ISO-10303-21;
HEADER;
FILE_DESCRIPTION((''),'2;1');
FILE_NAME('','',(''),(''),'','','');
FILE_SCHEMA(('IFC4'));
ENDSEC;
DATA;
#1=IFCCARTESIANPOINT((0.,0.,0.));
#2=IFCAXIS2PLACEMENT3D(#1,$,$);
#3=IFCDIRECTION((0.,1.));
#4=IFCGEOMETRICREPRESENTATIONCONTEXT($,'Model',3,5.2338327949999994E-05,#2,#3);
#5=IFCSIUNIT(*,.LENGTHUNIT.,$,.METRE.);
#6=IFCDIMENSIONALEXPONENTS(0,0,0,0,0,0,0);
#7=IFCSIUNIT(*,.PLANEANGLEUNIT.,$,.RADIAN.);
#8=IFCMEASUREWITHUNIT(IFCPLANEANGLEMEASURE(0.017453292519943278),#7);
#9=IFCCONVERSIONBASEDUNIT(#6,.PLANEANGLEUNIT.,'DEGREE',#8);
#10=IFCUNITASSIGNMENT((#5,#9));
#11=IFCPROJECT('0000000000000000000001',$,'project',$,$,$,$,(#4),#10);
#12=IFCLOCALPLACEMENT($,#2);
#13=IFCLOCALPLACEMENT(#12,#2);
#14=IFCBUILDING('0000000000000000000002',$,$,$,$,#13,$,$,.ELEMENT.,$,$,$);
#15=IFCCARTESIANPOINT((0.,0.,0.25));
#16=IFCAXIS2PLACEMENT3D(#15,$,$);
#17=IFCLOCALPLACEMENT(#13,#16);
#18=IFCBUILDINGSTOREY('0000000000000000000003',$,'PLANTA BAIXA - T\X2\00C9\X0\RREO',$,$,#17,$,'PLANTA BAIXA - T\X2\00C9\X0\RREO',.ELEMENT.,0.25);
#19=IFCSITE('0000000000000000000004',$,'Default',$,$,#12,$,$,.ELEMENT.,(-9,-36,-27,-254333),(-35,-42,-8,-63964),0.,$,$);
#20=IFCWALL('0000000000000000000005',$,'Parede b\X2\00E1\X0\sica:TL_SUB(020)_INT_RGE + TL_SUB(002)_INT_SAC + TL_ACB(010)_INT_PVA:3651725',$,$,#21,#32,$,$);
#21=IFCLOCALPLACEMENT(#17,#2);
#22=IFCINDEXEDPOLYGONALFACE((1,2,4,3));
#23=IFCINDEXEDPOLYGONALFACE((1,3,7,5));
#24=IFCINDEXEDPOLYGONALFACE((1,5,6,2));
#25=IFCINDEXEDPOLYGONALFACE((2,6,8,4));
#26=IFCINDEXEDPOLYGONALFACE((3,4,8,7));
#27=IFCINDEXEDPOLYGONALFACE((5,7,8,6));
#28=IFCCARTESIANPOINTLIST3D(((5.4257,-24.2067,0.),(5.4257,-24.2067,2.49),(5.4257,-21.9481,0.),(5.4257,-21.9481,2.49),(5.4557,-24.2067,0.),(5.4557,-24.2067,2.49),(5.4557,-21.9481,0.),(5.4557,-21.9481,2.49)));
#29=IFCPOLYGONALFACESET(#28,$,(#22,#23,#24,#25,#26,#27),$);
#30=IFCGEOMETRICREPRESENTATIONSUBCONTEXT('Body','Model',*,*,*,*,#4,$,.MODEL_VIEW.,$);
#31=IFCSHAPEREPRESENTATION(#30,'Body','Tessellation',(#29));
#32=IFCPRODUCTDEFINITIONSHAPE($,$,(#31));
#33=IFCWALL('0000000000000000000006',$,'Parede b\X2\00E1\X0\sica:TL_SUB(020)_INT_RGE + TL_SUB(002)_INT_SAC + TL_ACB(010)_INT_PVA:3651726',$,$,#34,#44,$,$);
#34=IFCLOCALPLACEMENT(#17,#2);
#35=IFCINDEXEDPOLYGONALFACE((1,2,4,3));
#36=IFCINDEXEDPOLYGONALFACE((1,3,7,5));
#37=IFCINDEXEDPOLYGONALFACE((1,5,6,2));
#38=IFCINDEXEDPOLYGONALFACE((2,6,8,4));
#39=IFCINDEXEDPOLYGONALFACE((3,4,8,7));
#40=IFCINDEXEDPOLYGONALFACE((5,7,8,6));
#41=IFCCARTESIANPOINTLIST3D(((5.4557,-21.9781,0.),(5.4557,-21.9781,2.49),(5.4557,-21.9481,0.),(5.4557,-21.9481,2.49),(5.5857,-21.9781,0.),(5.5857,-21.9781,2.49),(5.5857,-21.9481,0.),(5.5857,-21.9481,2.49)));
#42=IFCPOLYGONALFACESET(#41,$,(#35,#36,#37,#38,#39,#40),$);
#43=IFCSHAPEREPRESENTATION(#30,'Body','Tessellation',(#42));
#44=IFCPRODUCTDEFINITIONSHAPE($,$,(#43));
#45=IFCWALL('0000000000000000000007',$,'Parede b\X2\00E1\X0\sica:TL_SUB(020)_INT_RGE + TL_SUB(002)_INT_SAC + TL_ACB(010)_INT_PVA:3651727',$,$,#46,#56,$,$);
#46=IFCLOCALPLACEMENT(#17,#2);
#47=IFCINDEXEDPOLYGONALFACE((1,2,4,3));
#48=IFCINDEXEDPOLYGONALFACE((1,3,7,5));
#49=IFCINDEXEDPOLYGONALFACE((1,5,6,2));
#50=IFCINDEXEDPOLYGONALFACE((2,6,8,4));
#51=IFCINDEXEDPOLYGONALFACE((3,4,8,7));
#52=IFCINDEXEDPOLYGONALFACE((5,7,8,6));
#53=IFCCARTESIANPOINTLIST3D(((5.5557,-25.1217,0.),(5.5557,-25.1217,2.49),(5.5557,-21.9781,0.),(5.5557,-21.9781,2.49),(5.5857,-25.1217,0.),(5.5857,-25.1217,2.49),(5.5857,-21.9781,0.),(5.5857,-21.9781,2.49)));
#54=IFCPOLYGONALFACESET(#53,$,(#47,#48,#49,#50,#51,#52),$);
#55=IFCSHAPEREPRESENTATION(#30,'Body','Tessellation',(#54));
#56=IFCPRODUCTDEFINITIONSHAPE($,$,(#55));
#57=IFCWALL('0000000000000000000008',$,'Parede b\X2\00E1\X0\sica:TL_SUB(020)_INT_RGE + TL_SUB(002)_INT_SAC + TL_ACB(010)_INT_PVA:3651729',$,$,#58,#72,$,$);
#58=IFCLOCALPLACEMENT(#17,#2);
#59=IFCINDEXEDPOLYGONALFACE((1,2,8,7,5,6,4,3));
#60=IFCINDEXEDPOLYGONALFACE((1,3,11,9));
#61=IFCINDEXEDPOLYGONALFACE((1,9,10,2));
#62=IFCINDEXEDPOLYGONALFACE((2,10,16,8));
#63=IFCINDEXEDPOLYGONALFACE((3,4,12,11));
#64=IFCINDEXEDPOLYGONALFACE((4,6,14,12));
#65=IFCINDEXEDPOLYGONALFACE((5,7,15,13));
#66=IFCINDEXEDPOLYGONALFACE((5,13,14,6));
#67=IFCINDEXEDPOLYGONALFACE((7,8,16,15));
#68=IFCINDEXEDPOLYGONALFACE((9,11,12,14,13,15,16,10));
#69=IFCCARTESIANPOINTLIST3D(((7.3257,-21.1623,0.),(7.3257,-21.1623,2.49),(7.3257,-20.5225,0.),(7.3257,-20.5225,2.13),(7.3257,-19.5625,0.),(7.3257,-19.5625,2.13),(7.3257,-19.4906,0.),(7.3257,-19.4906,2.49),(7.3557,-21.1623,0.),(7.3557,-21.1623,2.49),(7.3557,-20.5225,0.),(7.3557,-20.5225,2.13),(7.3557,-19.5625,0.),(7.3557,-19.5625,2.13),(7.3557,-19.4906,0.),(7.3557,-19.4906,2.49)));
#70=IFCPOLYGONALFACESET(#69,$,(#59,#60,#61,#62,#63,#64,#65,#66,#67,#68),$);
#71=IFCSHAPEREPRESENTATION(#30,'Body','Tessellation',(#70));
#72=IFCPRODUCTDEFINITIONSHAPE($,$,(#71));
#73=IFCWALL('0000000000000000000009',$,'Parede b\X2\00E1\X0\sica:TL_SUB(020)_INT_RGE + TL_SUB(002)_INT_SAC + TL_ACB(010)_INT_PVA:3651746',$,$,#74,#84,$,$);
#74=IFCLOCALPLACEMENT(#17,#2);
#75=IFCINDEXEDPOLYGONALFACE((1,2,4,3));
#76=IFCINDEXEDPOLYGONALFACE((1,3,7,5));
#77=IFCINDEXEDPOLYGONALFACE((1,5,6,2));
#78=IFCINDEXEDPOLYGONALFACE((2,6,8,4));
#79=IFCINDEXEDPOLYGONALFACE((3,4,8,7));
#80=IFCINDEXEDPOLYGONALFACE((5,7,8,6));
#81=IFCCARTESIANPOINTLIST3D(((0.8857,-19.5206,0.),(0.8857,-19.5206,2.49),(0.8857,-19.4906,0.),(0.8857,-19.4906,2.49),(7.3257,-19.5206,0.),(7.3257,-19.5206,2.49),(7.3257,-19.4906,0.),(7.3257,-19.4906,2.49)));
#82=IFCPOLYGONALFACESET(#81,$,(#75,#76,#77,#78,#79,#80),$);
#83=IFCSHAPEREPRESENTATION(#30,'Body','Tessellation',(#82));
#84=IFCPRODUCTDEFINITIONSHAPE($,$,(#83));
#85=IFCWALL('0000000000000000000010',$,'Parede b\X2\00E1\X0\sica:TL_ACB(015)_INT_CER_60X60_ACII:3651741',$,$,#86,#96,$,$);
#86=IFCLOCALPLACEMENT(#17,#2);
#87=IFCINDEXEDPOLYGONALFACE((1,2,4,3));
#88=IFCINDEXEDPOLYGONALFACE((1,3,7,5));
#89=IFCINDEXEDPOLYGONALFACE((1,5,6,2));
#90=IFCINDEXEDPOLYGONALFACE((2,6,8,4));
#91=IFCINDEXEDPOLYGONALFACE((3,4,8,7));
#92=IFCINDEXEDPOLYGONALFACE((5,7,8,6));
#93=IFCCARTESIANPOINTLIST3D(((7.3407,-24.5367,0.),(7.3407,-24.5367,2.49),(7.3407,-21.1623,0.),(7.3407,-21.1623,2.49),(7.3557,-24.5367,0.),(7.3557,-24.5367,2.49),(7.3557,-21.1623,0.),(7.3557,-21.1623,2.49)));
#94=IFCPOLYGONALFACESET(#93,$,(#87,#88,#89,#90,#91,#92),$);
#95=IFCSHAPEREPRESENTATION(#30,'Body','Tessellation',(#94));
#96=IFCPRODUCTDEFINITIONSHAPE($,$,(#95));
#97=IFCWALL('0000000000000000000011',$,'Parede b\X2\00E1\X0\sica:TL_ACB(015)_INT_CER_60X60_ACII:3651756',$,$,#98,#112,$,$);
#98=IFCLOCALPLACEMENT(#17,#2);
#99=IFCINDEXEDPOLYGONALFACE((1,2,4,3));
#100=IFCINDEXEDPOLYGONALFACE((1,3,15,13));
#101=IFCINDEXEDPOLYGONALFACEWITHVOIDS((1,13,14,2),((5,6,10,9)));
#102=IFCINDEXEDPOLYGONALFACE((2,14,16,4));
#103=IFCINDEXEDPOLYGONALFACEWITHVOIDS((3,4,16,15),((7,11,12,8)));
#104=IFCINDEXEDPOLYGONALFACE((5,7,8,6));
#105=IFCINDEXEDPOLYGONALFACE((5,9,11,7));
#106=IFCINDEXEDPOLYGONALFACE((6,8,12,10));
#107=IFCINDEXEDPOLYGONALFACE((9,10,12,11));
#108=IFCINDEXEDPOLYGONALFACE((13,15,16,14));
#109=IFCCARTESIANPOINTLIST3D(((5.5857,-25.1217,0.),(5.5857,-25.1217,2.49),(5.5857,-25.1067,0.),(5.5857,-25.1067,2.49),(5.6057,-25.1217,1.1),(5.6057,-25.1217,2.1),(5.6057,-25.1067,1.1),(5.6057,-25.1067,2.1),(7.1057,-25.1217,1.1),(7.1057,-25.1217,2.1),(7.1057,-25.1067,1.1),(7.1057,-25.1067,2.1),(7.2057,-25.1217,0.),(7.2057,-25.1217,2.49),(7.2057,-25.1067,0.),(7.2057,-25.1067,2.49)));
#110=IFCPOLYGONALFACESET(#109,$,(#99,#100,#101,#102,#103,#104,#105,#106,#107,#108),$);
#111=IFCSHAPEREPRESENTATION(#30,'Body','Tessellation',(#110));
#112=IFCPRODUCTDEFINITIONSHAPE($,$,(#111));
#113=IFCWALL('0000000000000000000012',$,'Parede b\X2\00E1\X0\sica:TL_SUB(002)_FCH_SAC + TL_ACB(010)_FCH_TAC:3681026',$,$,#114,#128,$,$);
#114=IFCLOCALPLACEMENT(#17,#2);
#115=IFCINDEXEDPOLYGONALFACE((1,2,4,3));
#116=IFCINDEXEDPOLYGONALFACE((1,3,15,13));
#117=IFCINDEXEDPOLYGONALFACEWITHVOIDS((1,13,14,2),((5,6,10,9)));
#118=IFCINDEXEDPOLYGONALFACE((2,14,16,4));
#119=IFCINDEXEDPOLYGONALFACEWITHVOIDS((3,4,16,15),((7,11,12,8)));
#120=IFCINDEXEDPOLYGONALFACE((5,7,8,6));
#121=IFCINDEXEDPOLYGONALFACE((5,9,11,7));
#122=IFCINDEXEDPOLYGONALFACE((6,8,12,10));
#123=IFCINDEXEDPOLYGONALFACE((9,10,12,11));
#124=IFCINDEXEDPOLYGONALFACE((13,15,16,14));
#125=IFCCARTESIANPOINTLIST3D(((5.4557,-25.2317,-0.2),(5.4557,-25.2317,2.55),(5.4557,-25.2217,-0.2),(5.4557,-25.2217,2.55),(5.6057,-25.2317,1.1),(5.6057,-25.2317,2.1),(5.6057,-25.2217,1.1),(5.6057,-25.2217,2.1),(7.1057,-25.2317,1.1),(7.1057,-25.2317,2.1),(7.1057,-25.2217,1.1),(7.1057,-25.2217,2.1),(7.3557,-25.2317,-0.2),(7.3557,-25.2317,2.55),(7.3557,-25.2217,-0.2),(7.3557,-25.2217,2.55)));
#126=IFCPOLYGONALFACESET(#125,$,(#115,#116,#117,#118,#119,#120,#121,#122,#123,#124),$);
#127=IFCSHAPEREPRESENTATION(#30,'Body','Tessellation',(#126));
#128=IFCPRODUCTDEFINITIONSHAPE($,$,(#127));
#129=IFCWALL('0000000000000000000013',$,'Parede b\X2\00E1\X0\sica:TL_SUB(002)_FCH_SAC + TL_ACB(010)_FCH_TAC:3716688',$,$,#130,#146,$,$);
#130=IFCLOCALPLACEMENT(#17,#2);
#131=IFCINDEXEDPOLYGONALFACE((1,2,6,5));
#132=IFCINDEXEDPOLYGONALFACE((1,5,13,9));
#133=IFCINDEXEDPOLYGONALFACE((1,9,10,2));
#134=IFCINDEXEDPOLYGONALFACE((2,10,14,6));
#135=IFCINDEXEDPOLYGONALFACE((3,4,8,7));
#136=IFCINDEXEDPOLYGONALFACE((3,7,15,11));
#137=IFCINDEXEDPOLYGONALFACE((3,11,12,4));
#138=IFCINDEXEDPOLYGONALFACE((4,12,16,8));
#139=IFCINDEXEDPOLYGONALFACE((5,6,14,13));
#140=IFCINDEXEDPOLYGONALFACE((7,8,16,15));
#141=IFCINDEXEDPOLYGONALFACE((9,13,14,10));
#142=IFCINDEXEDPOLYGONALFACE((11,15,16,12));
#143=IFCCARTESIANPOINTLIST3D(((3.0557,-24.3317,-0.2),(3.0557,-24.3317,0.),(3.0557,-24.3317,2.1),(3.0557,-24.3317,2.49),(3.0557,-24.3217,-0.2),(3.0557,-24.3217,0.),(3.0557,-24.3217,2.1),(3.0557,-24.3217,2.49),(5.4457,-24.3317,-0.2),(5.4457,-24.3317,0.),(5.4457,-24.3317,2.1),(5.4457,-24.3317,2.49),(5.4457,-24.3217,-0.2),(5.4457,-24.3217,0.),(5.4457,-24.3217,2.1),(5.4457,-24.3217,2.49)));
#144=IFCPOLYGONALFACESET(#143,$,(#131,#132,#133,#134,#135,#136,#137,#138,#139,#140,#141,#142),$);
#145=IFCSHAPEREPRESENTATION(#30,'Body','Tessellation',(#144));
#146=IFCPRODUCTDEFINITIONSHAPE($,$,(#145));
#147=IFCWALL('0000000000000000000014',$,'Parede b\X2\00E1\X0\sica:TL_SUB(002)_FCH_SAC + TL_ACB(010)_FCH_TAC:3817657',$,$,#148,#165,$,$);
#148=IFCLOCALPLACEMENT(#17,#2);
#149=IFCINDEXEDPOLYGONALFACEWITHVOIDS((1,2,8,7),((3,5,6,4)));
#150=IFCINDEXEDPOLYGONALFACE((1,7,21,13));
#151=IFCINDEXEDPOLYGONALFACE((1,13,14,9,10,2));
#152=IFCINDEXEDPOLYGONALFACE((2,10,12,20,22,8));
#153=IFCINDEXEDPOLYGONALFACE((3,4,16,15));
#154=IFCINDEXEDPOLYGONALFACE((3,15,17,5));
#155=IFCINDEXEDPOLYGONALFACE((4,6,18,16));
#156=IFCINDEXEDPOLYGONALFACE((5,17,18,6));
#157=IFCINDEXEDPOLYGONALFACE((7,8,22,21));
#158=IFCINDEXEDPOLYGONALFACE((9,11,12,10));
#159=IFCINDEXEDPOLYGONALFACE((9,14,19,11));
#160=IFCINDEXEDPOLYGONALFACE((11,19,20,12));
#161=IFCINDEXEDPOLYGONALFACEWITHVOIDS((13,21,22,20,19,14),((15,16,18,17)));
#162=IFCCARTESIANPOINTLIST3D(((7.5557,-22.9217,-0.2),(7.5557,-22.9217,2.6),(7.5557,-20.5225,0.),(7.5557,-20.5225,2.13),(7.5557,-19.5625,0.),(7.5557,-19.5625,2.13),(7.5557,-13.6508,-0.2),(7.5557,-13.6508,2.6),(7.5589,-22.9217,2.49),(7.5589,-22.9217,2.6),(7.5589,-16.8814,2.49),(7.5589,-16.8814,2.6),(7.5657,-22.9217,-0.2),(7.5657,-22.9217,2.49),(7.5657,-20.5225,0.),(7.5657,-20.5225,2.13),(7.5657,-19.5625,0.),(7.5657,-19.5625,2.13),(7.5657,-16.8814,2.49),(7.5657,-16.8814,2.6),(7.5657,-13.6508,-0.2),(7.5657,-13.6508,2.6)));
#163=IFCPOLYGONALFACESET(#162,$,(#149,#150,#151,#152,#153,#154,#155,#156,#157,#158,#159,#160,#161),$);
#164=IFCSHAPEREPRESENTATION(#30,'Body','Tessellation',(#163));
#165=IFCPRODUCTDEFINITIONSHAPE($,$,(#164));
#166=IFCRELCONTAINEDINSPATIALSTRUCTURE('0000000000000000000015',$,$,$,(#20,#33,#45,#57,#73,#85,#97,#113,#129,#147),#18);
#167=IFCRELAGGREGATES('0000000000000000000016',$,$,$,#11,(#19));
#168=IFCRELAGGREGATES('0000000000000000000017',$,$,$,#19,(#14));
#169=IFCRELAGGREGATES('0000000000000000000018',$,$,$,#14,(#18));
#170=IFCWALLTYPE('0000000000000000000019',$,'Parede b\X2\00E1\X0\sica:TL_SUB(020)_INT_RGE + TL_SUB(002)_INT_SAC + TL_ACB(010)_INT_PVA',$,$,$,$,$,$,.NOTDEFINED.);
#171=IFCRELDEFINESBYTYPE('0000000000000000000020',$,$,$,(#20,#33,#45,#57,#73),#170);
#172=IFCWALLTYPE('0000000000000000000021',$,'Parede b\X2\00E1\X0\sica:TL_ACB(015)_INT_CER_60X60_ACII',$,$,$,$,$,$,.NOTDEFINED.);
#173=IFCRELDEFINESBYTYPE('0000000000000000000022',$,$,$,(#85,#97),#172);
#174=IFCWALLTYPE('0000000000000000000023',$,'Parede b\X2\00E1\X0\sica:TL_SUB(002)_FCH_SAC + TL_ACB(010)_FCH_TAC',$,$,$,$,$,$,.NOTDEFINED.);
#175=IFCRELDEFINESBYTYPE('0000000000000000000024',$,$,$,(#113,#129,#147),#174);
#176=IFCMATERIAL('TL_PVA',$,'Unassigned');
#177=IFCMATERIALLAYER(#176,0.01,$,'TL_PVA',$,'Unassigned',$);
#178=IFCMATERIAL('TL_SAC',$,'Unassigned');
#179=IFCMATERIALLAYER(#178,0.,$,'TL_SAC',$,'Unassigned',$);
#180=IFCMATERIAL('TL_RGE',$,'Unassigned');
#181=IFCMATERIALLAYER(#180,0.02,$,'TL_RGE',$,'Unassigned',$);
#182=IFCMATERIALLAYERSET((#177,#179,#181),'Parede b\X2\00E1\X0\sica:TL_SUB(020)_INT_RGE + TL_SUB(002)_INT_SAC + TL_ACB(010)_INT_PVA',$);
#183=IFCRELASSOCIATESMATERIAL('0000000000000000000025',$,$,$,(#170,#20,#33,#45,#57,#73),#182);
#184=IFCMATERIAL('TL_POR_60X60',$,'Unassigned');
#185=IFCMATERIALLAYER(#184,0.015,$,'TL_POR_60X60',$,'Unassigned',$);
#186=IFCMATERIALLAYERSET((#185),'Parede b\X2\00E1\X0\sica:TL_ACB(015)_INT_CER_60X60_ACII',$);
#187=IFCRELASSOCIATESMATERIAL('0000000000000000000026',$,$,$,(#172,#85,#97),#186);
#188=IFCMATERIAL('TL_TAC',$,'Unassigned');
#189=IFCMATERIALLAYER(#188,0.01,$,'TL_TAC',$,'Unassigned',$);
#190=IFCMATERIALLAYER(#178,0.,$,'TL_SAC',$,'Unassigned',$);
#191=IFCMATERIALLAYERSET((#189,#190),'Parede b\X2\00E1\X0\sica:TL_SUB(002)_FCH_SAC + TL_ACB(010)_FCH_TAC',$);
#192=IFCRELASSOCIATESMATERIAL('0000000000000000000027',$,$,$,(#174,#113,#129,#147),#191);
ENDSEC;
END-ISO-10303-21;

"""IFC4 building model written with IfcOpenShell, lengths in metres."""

from ifc_helpers import new_model, entity, si_unit, converted_unit, direction, frame, frame_2d, origin, place, context, subcontext, project, spatial, polyline, rectangle, extrude, clip, bounded_halfspace, material, layer, layer_set, layer_usage, type_object, element, save


model = new_model("IFC4")

# Units and contexts
model_context = context("Model", 3, precision=5.2338327949999994e-05, world=origin(), true_north=direction((0.0, 1.0)))
body_context = subcontext(model_context, "Body", "Model", "MODEL_VIEW")
ifc_project = project(units=[si_unit("LENGTHUNIT", "METRE"), converted_unit("PLANEANGLEUNIT", "DEGREE", entity("IfcPlaneAngleMeasure", 0.017453292519943278), si_unit("PLANEANGLEUNIT", "RADIAN"), dimensions=[0, 0, 0, 0, 0, 0, 0])], contexts=[model_context])

# Site, building, storey
site_placement = place(None, frame((0.0, 0.0, 0.0)))
site = spatial("IfcSite", under=ifc_project, at=site_placement, Name="Default", CompositionType="ELEMENT", RefLatitude=(-9, -36, -27, -254333), RefLongitude=(-35, -42, -8, -63964), RefElevation=0.0)
building_placement = place(site_placement, origin())
building = spatial("IfcBuilding", under=site, at=building_placement, CompositionType="ELEMENT")
storey_placement = place(building_placement, frame((0.0, 0.0, 0.25)))
storey = spatial("IfcBuildingStorey", under=building, at=storey_placement, Name="PLANTA BAIXA - TÉRREO", LongName="PLANTA BAIXA - TÉRREO", CompositionType="ELEMENT", Elevation=0.25)

# Walls
ifc_material_1 = material(Name="TL_PVA", Category="Unassigned")
ifc_layer_1 = layer(ifc_material_1, 0.01, Name="TL_PVA", Category="Unassigned")
ifc_material_2 = material(Name="TL_SAC", Category="Unassigned")
ifc_layer_2 = layer(ifc_material_2, 0.0, Name="TL_SAC", Category="Unassigned")
ifc_material_3 = material(Name="TL_RGE", Category="Unassigned")
ifc_layer_3 = layer(ifc_material_3, 0.02, Name="TL_RGE", Category="Unassigned")
ifc_layer_set_1 = layer_set([ifc_layer_1, ifc_layer_2, ifc_layer_3], Name="Parede básica:TL_SUB(020)_INT_RGE + TL_SUB(002)_INT_SAC + TL_ACB(010)_INT_PVA")
wall_type_1 = type_object("IfcWallType", Name="Parede básica:TL_SUB(020)_INT_RGE + TL_SUB(002)_INT_SAC + TL_ACB(010)_INT_PVA", PredefinedType="NOTDEFINED", material=ifc_layer_set_1)
ifc_layer_usage_1 = layer_usage(ifc_layer_set_1, "AXIS2", "POSITIVE", -0.015)
wall_1_placement = place(storey_placement, frame((5.4407, -21.9481, 0.0), z_axis=(0.0, 0.0, 1.0), x_axis=(0.0, -1.0, 0.0)))
element("IfcWall", 1, at=wall_1_placement, inside=storey, type_object=wall_type_1, material=ifc_layer_usage_1, Name="Parede básica:TL_SUB(020)_INT_RGE + TL_SUB(002)_INT_SAC + TL_ACB(010)_INT_PVA:3651725", context=body_context, shape_type="SweptSolid", body=[
    extrude(rectangle(XDim=2.2587, YDim=0.03, at=frame_2d((1.1293, 0.0), x_axis=(-1.0, 0.0))), origin(), (0.0, 0.0, 1.0), 2.49),
])
ifc_layer_usage_2 = layer_usage(ifc_layer_set_1, "AXIS2", "POSITIVE", -0.015)
wall_2_placement = place(storey_placement, frame((5.5857, -21.9631, 0.0), z_axis=(0.0, 0.0, 1.0), x_axis=(-1.0, 0.0, 0.0)))
element("IfcWall", 2, at=wall_2_placement, inside=storey, type_object=wall_type_1, material=ifc_layer_usage_2, Name="Parede básica:TL_SUB(020)_INT_RGE + TL_SUB(002)_INT_SAC + TL_ACB(010)_INT_PVA:3651726", context=body_context, shape_type="SweptSolid", body=[
    extrude(rectangle(XDim=0.13, YDim=0.03, at=frame_2d((0.065, 0.0), x_axis=(-1.0, 0.0))), origin(), (0.0, 0.0, 1.0), 2.49),
])
ifc_layer_usage_3 = layer_usage(ifc_layer_set_1, "AXIS2", "POSITIVE", -0.015)
wall_3_placement = place(storey_placement, frame((5.5707, -25.1217, 0.0), z_axis=(0.0, 0.0, 1.0), x_axis=(0.0, 1.0, 0.0)))
element("IfcWall", 3, at=wall_3_placement, inside=storey, type_object=wall_type_1, material=ifc_layer_usage_3, Name="Parede básica:TL_SUB(020)_INT_RGE + TL_SUB(002)_INT_SAC + TL_ACB(010)_INT_PVA:3651727", context=body_context, shape_type="SweptSolid", body=[
    extrude(rectangle(XDim=3.1437, YDim=0.03, at=frame_2d((1.5718, 0.0), x_axis=(-1.0, 0.0))), origin(), (0.0, 0.0, 1.0), 2.49),
])

# Wall, opening
ifc_layer_usage_4 = layer_usage(ifc_layer_set_1, "AXIS2", "POSITIVE", -0.015)
wall_4_placement = place(storey_placement, frame((7.3407, -19.4906, 0.0), z_axis=(0.0, 0.0, 1.0), x_axis=(0.0, -1.0, 0.0)))
wall_4 = element("IfcWall", 4, at=wall_4_placement, inside=storey, type_object=wall_type_1, material=ifc_layer_usage_4, Name="Parede básica:TL_SUB(020)_INT_RGE + TL_SUB(002)_INT_SAC + TL_ACB(010)_INT_PVA:3651729", context=body_context, shape_type="SweptSolid", body=[
    extrude(rectangle(XDim=1.6717, YDim=0.03, at=frame_2d((0.8359, 0.0), x_axis=(-1.0, 0.0))), origin(), (0.0, 0.0, 1.0), 2.49),
])
opening_1_placement = place(wall_4_placement, frame((-19.4906, -7.3407, 0.0)))
element("IfcOpeningElement", 5, at=opening_1_placement, cuts=wall_4, PredefinedType="OPENING", context=body_context, shape_type="SweptSolid", body=[
    extrude(rectangle(XDim=2.13, YDim=0.96, at=frame_2d((0.0, 0.0), x_axis=(0.0, 1.0))), frame((20.0425, 5.8317, 1.065), z_axis=(0.0, 1.0, 0.0), x_axis=(-1.0, 0.0, 0.0)), (0.0, 0.0, 1.0), 3.048),
])

# Walls
ifc_layer_usage_5 = layer_usage(ifc_layer_set_1, "AXIS2", "NEGATIVE", 0.015)
wall_5_placement = place(storey_placement, frame((7.3257, -19.5056, 0.0), z_axis=(0.0, 0.0, 1.0), x_axis=(-1.0, 0.0, 0.0)))
element("IfcWall", 6, at=wall_5_placement, inside=storey, type_object=wall_type_1, material=ifc_layer_usage_5, Name="Parede básica:TL_SUB(020)_INT_RGE + TL_SUB(002)_INT_SAC + TL_ACB(010)_INT_PVA:3651746", context=body_context, shape_type="SweptSolid", body=[
    extrude(rectangle(XDim=6.44, YDim=0.03, at=frame_2d((3.22, 0.0), x_axis=(-1.0, 0.0))), origin(), (0.0, 0.0, 1.0), 2.49),
])
ifc_material_4 = material(Name="TL_POR_60X60", Category="Unassigned")
ifc_layer_4 = layer(ifc_material_4, 0.015, Name="TL_POR_60X60", Category="Unassigned")
ifc_layer_set_2 = layer_set([ifc_layer_4], Name="Parede básica:TL_ACB(015)_INT_CER_60X60_ACII")
ifc_layer_usage_6 = layer_usage(ifc_layer_set_2, "AXIS2", "POSITIVE", -0.0075)
wall_type_2 = type_object("IfcWallType", Name="Parede básica:TL_ACB(015)_INT_CER_60X60_ACII", PredefinedType="NOTDEFINED", material=ifc_layer_set_2)
wall_6_placement = place(storey_placement, frame((7.3482, -21.1623, 0.0), z_axis=(0.0, 0.0, 1.0), x_axis=(0.0, -1.0, 0.0)))
element("IfcWall", 7, at=wall_6_placement, inside=storey, type_object=wall_type_2, material=ifc_layer_usage_6, Name="Parede básica:TL_ACB(015)_INT_CER_60X60_ACII:3651741", context=body_context, shape_type="SweptSolid", body=[
    extrude(rectangle(XDim=3.3744, YDim=0.015, at=frame_2d((1.6872, 0.0), x_axis=(-1.0, 0.0))), origin(), (0.0, 0.0, 1.0), 2.49),
])

# Walls, openings
ifc_layer_usage_7 = layer_usage(ifc_layer_set_2, "AXIS2", "POSITIVE", -0.0075)
wall_7_placement = place(storey_placement, frame((7.2057, -25.1142, 0.0), z_axis=(0.0, 0.0, 1.0), x_axis=(-1.0, 0.0, 0.0)))
wall_7 = element("IfcWall", 8, at=wall_7_placement, inside=storey, type_object=wall_type_2, material=ifc_layer_usage_7, Name="Parede básica:TL_ACB(015)_INT_CER_60X60_ACII:3651756", context=body_context, shape_type="SweptSolid", body=[
    extrude(rectangle(XDim=1.62, YDim=0.015, at=frame_2d((0.81, 0.0), x_axis=(-1.0, 0.0))), origin(), (0.0, 0.0, 1.0), 2.49),
])
opening_2_placement = place(wall_7_placement, frame((7.2057, -25.1142, 1.1)))
element("IfcOpeningElement", 9, at=opening_2_placement, cuts=wall_7, PredefinedType="OPENING", context=body_context, shape_type="SweptSolid", body=[
    extrude(rectangle(XDim=1.0, YDim=1.5, at=frame_2d((0.0, 0.0), x_axis=(0.0, 1.0))), frame((-6.3557, 23.5977, 0.5), z_axis=(0.0, 1.0, 0.0), x_axis=(1.0, 0.0, 0.0)), (0.0, 0.0, 1.0), 3.048),
])
ifc_material_5 = material(Name="TL_TAC", Category="Unassigned")
ifc_layer_5 = layer(ifc_material_5, 0.01, Name="TL_TAC", Category="Unassigned")
ifc_layer_6 = layer(ifc_material_2, 0.0, Name="TL_SAC", Category="Unassigned")
ifc_layer_set_3 = layer_set([ifc_layer_5, ifc_layer_6], Name="Parede básica:TL_SUB(002)_FCH_SAC + TL_ACB(010)_FCH_TAC")
ifc_layer_usage_8 = layer_usage(ifc_layer_set_3, "AXIS2", "POSITIVE", -0.005)
wall_type_3 = type_object("IfcWallType", Name="Parede básica:TL_SUB(002)_FCH_SAC + TL_ACB(010)_FCH_TAC", PredefinedType="NOTDEFINED", material=ifc_layer_set_3)
wall_8_placement = place(storey_placement, frame((7.3557, -25.2267, -0.2), z_axis=(0.0, 0.0, 1.0), x_axis=(-1.0, 0.0, 0.0)))
wall_8 = element("IfcWall", 10, at=wall_8_placement, inside=storey, type_object=wall_type_3, material=ifc_layer_usage_8, Name="Parede básica:TL_SUB(002)_FCH_SAC + TL_ACB(010)_FCH_TAC:3681026", context=body_context, shape_type="SweptSolid", body=[
    extrude(rectangle(XDim=1.9, YDim=0.01, at=frame_2d((0.95, 0.0), x_axis=(-1.0, 0.0))), origin(), (0.0, 0.0, 1.0), 2.75),
])
opening_3_placement = place(wall_8_placement, frame((7.3557, -25.2267, 1.3)))
element("IfcOpeningElement", 11, at=opening_3_placement, cuts=wall_8, PredefinedType="OPENING", context=body_context, shape_type="SweptSolid", body=[
    extrude(rectangle(XDim=1.0, YDim=1.5, at=frame_2d((0.0, 0.0), x_axis=(0.0, 1.0))), frame((-6.3557, 23.5977, 0.5), z_axis=(0.0, 1.0, 0.0), x_axis=(1.0, 0.0, 0.0)), (0.0, 0.0, 1.0), 3.048),
])
ifc_layer_usage_9 = layer_usage(ifc_layer_set_3, "AXIS2", "NEGATIVE", 0.005)
wall_9_placement = place(storey_placement, frame((5.4457, -24.3267, -0.2), z_axis=(0.0, 0.0, 1.0), x_axis=(-1.0, 0.0, 0.0)))
wall_9 = element("IfcWall", 12, at=wall_9_placement, inside=storey, type_object=wall_type_3, material=ifc_layer_usage_9, Name="Parede básica:TL_SUB(002)_FCH_SAC + TL_ACB(010)_FCH_TAC:3716688", context=body_context, shape_type="SweptSolid", body=[
    extrude(rectangle(XDim=2.39, YDim=0.01, at=frame_2d((1.195, 0.0), x_axis=(-1.0, 0.0))), origin(), (0.0, 0.0, 1.0), 2.69),
])
opening_4_placement = place(wall_9_placement, frame((5.4457, -24.3267, 0.2)))
element("IfcOpeningElement", 13, at=opening_4_placement, cuts=wall_9, PredefinedType="OPENING", context=body_context, shape_type="SweptSolid", body=[
    extrude(rectangle(XDim=2.1, YDim=2.4, at=frame_2d((0.0, 0.0), x_axis=(0.0, 1.0))), frame((-4.2557, 22.7977, 1.05), z_axis=(0.0, 1.0, 0.0), x_axis=(-1.0, 0.0, 0.0)), (0.0, 0.0, 1.0), 3.048),
])
ifc_layer_usage_10 = layer_usage(ifc_layer_set_3, "AXIS2", "NEGATIVE", 0.005)
wall_10_placement = place(storey_placement, frame((7.5607, -22.9217, -0.2), z_axis=(0.0, 0.0, 1.0), x_axis=(0.0, 1.0, 0.0)))
wall_10 = element("IfcWall", 14, at=wall_10_placement, inside=storey, type_object=wall_type_3, material=ifc_layer_usage_10, Name="Parede básica:TL_SUB(002)_FCH_SAC + TL_ACB(010)_FCH_TAC:3817657", context=body_context, shape_type="Clipping", body=[
    clip(extrude(rectangle(XDim=9.2709, YDim=0.01, at=frame_2d((4.6355, 0.0), x_axis=(-1.0, 0.0))), origin(), (0.0, 0.0, 1.0), 2.8), bounded_halfspace(frame((0.0, -0.005, 2.69), z_axis=(0.0, 0.0, -1.0), x_axis=(-1.0, 0.0, 0.0)), True, frame((0.0, -0.005, 2.69)), polyline([(0.0, 0.0), (0.01, 0.0), (6.0403, 0.0), (6.0403, 0.0068), (0.0, 0.0068), (0.0, 0.0)]))),
])
opening_5_placement = place(wall_10_placement, frame((22.9217, 7.5607, 0.2)))
element("IfcOpeningElement", 15, at=opening_5_placement, cuts=wall_10, PredefinedType="OPENING", context=body_context, shape_type="SweptSolid", body=[
    extrude(rectangle(XDim=2.13, YDim=0.96, at=frame_2d((0.0, 0.0), x_axis=(1.0, 0.0))), frame((-20.0425, -8.8797, 1.065), z_axis=(0.0, 1.0, 0.0), x_axis=(0.0, 0.0, 1.0)), (0.0, 0.0, 1.0), 3.048),
])

save(model, "model.ifc")
